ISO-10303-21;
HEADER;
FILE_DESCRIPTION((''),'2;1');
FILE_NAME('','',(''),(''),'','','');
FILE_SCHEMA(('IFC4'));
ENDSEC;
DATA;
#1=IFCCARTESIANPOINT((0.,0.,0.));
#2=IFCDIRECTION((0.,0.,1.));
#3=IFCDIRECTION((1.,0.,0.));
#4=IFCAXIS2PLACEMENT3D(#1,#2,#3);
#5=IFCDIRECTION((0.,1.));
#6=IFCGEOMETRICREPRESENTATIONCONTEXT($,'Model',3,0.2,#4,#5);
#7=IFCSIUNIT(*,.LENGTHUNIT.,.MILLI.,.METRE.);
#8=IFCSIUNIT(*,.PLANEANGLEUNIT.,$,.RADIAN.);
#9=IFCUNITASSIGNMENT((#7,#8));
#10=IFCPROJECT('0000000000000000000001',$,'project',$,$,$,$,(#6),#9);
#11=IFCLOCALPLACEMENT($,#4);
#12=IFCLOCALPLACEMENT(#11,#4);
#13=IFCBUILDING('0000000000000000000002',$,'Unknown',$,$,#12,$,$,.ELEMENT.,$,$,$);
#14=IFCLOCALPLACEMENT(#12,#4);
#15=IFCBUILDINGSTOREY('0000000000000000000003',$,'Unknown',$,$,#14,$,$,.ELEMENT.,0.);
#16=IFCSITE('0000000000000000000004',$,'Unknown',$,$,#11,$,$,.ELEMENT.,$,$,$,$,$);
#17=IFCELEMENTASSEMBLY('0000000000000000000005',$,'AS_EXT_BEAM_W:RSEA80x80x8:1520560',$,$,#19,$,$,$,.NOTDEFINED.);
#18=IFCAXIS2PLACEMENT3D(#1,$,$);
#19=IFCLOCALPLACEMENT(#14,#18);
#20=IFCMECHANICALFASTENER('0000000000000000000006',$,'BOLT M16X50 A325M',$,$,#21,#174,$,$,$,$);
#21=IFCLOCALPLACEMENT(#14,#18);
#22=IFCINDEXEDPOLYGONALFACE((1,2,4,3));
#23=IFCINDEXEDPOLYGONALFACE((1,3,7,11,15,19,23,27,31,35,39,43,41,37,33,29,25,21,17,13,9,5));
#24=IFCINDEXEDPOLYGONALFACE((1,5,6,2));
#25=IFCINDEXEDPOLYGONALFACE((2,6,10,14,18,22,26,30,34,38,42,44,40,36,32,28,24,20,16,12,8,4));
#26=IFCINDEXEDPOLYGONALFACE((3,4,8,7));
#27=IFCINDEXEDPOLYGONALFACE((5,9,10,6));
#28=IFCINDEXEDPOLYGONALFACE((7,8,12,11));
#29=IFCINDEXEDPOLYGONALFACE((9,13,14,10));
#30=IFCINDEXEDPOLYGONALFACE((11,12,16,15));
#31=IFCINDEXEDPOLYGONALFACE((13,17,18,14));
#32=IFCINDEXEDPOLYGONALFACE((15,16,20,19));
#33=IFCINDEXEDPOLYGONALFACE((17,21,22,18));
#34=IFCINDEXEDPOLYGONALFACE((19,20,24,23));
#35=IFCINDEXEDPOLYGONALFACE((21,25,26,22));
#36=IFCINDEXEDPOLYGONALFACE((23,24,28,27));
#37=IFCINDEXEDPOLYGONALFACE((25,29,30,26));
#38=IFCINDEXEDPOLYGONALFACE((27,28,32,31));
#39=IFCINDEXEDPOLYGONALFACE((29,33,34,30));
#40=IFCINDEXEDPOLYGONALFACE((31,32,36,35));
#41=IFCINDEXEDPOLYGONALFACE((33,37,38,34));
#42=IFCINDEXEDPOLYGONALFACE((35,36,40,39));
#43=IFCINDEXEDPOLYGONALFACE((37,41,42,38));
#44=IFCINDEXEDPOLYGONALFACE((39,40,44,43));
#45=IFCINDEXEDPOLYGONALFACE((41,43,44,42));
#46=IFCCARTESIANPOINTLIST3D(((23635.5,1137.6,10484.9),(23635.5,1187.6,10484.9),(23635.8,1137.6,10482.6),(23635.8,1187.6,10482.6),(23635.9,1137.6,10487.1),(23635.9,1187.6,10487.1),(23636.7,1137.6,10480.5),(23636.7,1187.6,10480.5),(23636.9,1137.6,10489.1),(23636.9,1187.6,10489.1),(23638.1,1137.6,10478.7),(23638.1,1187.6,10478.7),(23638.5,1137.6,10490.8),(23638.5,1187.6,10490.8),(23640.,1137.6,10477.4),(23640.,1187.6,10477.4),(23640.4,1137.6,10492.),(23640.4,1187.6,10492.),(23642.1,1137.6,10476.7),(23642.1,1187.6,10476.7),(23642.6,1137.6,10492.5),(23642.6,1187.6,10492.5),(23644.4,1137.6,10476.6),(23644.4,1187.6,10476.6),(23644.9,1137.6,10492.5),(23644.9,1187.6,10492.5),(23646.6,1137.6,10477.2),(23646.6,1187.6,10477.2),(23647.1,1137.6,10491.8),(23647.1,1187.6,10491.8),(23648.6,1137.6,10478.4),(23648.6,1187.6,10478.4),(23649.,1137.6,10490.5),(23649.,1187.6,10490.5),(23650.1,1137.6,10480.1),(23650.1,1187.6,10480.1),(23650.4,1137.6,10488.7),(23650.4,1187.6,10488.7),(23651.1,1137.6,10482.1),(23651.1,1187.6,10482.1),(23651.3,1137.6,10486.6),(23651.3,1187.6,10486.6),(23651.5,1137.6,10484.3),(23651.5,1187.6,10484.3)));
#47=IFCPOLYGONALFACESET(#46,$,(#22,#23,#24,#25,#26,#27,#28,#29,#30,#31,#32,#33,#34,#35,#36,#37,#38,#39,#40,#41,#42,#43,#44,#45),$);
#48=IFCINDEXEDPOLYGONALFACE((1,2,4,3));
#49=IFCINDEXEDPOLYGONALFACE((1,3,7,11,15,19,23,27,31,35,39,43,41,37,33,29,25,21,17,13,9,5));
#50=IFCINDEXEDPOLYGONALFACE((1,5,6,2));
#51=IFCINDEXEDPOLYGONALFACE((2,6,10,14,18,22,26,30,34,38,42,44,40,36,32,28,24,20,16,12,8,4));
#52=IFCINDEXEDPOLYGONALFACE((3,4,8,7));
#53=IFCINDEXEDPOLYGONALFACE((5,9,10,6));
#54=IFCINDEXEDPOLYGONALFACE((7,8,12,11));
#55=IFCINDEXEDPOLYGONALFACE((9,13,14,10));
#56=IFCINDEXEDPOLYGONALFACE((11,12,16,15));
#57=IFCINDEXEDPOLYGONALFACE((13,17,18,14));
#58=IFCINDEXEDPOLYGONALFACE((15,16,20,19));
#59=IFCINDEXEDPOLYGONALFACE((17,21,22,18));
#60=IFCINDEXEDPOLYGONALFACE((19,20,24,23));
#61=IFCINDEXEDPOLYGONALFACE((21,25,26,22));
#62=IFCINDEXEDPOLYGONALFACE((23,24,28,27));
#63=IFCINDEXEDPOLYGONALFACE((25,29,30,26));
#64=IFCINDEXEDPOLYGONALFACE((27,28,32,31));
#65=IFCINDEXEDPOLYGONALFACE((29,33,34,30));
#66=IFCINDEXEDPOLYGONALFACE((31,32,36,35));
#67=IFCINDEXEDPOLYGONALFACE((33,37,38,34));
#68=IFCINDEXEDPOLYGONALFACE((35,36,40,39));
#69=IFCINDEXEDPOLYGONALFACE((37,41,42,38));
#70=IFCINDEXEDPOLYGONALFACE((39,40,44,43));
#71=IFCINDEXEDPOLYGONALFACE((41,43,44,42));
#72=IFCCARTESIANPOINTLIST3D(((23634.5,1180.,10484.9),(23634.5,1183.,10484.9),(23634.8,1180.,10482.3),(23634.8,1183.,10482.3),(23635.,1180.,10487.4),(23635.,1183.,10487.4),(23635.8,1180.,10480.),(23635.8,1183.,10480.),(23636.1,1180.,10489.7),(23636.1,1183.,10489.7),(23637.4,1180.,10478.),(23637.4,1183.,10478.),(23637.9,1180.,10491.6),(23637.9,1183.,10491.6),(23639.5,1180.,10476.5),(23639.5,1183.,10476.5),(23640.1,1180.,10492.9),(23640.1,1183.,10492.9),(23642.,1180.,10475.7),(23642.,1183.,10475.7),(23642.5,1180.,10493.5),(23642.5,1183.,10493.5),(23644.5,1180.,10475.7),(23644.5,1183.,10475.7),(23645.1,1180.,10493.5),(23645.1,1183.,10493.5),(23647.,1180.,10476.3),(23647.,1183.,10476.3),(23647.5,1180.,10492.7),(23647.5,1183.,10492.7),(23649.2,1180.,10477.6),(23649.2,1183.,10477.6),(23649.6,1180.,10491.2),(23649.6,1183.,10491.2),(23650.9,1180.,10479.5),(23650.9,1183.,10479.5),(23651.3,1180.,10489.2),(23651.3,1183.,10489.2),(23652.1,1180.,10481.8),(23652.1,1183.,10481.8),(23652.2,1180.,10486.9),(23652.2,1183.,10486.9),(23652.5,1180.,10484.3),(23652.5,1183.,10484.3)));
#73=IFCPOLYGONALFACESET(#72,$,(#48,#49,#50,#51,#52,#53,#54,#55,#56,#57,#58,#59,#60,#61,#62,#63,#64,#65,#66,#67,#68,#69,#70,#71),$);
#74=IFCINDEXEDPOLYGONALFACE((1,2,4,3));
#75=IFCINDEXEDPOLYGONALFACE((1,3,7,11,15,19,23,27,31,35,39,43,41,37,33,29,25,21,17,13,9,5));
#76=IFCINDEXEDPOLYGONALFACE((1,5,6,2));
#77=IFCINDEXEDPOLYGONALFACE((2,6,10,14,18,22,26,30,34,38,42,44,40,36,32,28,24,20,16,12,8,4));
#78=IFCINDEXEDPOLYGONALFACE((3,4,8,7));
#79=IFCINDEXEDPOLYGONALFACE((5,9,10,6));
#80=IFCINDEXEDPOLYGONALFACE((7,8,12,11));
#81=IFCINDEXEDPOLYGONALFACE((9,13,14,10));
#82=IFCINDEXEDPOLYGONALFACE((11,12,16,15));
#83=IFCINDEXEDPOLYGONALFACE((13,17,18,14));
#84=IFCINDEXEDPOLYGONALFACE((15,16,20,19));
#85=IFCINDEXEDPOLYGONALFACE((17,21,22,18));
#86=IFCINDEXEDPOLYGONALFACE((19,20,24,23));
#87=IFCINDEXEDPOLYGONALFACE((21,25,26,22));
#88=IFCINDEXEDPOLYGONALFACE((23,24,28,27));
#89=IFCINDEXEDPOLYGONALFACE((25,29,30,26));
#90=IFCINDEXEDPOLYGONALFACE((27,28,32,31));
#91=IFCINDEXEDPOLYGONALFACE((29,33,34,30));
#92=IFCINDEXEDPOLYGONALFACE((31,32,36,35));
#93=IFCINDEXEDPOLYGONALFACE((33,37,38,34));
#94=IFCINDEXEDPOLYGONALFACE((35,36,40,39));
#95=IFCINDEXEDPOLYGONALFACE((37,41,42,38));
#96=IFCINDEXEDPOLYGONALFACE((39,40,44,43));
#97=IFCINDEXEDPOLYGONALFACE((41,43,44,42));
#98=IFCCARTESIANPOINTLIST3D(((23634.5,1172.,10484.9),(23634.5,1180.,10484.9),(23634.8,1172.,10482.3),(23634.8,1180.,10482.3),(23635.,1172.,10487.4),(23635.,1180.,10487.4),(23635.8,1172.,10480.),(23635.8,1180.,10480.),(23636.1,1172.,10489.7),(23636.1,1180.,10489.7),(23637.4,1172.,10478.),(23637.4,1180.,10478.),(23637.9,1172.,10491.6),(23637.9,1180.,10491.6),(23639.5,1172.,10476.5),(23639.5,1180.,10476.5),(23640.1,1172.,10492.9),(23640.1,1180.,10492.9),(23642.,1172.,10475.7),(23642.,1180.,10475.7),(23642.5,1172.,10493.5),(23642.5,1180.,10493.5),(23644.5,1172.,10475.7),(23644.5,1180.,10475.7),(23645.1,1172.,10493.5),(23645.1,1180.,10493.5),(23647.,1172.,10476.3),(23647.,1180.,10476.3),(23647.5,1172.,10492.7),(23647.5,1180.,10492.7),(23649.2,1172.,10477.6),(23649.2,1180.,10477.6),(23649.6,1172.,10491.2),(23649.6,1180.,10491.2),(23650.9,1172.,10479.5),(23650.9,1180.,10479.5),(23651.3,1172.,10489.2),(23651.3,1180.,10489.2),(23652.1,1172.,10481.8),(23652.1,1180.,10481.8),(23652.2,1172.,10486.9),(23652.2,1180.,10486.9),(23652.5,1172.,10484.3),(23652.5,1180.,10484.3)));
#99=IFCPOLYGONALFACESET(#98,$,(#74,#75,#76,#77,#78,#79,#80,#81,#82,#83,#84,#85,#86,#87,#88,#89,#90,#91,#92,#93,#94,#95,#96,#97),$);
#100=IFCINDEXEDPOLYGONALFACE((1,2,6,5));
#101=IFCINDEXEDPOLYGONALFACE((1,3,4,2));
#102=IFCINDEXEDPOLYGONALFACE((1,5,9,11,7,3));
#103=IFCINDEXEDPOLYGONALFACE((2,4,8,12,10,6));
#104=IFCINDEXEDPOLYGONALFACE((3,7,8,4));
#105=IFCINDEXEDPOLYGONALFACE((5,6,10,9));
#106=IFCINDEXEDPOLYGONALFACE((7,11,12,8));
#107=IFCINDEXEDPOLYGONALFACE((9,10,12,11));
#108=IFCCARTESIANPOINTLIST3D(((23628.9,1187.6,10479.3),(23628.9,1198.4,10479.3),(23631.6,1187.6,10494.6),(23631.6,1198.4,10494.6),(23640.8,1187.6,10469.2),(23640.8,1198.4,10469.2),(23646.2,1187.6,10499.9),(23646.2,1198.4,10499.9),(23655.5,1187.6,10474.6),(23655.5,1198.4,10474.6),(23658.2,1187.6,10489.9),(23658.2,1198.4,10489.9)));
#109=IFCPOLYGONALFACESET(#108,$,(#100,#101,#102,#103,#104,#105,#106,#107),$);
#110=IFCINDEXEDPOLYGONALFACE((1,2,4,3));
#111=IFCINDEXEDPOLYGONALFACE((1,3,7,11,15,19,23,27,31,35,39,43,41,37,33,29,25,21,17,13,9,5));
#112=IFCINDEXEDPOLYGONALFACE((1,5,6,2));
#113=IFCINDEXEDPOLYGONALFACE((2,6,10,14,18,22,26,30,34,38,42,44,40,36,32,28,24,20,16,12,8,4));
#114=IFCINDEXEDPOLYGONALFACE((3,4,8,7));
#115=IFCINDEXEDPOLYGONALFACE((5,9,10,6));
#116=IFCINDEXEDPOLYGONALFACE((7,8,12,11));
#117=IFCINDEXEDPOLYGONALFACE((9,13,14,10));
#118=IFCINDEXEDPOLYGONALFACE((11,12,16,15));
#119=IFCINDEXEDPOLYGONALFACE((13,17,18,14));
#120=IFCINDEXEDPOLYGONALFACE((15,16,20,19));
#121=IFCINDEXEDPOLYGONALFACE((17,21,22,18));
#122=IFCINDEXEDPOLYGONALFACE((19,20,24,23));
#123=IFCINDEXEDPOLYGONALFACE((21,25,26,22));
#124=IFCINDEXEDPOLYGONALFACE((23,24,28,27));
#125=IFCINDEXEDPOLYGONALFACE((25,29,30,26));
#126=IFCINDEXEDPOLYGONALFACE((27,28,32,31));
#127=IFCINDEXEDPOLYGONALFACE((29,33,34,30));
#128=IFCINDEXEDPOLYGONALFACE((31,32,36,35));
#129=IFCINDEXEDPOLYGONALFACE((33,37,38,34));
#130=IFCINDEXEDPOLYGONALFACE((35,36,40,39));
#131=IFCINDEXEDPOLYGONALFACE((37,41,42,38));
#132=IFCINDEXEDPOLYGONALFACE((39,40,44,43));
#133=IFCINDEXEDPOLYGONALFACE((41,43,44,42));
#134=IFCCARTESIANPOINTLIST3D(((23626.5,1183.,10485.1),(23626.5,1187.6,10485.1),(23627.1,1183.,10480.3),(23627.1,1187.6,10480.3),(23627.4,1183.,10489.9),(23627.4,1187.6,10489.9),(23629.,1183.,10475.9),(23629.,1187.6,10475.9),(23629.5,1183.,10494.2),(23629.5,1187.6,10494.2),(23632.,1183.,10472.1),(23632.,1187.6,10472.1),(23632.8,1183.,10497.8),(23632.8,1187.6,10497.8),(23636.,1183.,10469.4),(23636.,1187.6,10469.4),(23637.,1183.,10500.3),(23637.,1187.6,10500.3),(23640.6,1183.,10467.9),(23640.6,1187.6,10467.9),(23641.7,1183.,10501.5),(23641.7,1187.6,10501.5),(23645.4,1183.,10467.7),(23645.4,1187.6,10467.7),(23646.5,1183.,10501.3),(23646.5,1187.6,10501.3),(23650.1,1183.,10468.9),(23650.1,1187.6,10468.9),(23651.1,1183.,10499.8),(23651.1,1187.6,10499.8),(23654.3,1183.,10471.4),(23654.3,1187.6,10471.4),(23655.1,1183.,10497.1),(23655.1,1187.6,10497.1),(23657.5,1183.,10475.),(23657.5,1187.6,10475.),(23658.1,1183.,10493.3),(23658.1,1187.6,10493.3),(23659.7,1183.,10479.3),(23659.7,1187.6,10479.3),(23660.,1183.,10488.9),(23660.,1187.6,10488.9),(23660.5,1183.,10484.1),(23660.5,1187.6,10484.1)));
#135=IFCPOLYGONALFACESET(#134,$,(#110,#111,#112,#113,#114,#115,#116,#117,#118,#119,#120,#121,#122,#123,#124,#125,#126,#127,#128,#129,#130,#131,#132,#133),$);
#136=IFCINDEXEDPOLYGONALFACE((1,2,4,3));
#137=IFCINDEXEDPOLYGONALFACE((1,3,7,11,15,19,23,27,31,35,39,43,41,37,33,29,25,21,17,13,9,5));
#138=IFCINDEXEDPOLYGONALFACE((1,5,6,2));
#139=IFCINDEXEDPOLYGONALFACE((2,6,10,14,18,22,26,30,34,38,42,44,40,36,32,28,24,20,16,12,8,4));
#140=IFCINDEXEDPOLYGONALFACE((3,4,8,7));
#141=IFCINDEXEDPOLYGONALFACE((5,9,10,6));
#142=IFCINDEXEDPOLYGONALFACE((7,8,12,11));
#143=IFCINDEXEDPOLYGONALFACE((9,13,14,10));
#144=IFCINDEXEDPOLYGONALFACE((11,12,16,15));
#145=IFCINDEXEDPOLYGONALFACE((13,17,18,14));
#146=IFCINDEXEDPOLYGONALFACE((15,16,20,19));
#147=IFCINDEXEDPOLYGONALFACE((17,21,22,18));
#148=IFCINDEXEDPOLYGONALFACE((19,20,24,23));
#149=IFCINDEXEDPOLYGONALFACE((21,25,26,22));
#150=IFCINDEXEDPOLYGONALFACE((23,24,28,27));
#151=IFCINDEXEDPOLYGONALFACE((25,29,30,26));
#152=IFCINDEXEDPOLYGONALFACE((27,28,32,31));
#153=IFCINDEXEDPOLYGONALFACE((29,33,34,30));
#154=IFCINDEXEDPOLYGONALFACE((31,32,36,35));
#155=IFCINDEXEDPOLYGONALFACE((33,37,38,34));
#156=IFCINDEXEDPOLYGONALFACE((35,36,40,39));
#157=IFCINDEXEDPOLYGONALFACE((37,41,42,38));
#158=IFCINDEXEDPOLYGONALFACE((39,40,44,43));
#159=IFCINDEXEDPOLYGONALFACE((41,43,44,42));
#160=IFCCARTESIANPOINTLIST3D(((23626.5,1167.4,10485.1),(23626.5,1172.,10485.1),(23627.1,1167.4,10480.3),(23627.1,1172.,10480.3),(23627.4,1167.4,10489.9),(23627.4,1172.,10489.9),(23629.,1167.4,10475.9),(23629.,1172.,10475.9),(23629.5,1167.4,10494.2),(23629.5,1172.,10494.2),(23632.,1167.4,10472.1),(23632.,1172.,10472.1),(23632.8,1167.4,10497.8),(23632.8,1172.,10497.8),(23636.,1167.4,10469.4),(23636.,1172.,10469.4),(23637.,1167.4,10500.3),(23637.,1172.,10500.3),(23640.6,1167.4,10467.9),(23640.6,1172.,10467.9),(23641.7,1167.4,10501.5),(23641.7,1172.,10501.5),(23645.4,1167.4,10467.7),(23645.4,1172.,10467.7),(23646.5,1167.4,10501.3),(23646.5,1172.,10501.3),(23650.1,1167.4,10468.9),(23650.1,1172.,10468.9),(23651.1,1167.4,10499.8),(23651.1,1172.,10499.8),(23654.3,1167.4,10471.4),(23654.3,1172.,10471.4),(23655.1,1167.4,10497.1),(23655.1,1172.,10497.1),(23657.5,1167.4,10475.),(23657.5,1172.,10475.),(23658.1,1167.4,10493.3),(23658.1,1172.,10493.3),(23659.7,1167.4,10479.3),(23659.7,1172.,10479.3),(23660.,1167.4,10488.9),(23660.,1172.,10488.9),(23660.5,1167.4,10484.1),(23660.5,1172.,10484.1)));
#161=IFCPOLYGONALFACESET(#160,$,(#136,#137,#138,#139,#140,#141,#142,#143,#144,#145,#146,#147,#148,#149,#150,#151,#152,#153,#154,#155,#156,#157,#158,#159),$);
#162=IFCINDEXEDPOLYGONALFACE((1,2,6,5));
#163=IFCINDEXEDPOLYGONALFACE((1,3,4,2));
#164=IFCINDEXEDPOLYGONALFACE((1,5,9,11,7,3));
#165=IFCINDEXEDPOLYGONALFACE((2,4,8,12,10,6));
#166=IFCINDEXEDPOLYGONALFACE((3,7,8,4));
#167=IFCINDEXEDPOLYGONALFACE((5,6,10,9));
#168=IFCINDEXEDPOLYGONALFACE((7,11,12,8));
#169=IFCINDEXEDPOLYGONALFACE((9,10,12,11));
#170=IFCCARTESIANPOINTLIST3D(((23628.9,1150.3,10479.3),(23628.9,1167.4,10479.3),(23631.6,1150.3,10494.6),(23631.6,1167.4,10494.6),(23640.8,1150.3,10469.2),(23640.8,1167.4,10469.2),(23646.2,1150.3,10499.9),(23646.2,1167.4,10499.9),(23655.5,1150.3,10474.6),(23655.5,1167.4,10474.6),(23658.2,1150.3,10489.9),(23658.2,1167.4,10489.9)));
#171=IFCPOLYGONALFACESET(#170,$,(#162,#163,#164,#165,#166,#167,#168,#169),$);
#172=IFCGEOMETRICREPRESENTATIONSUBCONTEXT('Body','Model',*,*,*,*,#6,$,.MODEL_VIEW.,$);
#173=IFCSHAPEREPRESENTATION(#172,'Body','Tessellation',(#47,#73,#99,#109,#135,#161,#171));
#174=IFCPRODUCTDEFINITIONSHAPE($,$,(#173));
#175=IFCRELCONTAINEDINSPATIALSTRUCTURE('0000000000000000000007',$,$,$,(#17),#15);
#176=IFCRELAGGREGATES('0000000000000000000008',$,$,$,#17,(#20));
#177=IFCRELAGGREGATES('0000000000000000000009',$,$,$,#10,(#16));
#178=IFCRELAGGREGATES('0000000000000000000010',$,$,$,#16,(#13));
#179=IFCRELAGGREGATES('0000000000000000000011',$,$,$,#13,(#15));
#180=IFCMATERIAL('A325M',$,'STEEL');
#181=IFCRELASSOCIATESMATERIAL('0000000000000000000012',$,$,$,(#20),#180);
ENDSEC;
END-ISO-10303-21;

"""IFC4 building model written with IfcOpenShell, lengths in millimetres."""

from ifc_helpers import new_model, si_unit, direction, frame, origin_with_axes, place, context, subcontext, project, spatial, line, arc, indexed_curve, outline, extrude, source, transform, mapped, material, element, aggregate, save


model = new_model("IFC4")

# Units and contexts
model_context = context("Model", 3, precision=0.2, world=origin_with_axes(), true_north=direction((0.0, 1.0)))
body_context = subcontext(model_context, "Body", "Model", "MODEL_VIEW")
ifc_project = project(units=[si_unit("LENGTHUNIT", "METRE", prefix="MILLI"), si_unit("PLANEANGLEUNIT", "RADIAN")], contexts=[model_context])

# Site, building, storey
site_placement = place(None, origin_with_axes())
site = spatial("IfcSite", under=ifc_project, at=site_placement, Name="Unknown", CompositionType="ELEMENT")
building_placement = place(site_placement, origin_with_axes())
building = spatial("IfcBuilding", under=site, at=building_placement, Name="Unknown", CompositionType="ELEMENT")
storey_placement = place(building_placement, origin_with_axes())
storey = spatial("IfcBuildingStorey", under=building, at=storey_placement, Name="Unknown", CompositionType="ELEMENT", Elevation=0.0)

# Element assembly
assembly_1_placement = place(storey_placement, frame((23581.1, 1140.0, 10490.5), z_axis=(0.0, -1.0, 0.0), x_axis=(0.984808, 0.0, -0.173648)))
assembly_1 = element("IfcElementAssembly", 1, at=assembly_1_placement, inside=storey, Name="AS_EXT_BEAM_W:RSEA80x80x8:1520560", PredefinedType="NOTDEFINED")

# Mechanical fastener
ifc_material_1 = material(Name="A325M", Category="STEEL")
shared_shape = source(origin_with_axes(), body_context, "Body", "SweptSolid", [
    extrude(outline(indexed_curve([(8.0, 0.0), (0.0, 8.0), (-8.0, 0.0), (0.0, -8.0)], segments=[arc(1, 2, 3), arc(3, 4, 1)])), frame((0.0, 0.0, 15.6), z_axis=(0.0, 0.0, -1.0), x_axis=(0.0, 1.0, 0.0)), (0.0, 0.0, 1.0), 50.0),
    extrude(outline(indexed_curve([(9.0, 0.0), (0.0, 9.0), (-9.0, 0.0), (0.0, -9.0)], segments=[arc(1, 2, 3), arc(3, 4, 1)])), frame((0.0, 0.0, 11.0), z_axis=(0.0, 0.0, -1.0), x_axis=(0.0, 1.0, 0.0)), (0.0, 0.0, 1.0), 3.0),
    extrude(outline(indexed_curve([(9.0, 0.0), (0.0, 9.0), (-9.0, 0.0), (0.0, -9.0)], segments=[arc(1, 2, 3), arc(3, 4, 1)])), frame((0.0, 0.0, 8.0), z_axis=(0.0, 0.0, -1.0), x_axis=(0.0, 1.0, 0.0)), (0.0, 0.0, 1.0), 8.0),
    extrude(outline(indexed_curve([(15.6, 0.0), (7.8, 13.5), (-7.8, 13.5), (-15.6, 0.0), (-7.8, -13.5), (7.8, -13.5)], segments=[line(1, 2, 3, 4, 5, 6, 1)])), frame((0.0, 0.0, 26.4), z_axis=(0.0, 0.0, -1.0), x_axis=(0.0, 1.0, 0.0)), (0.0, 0.0, 1.0), 10.8),
    extrude(outline(indexed_curve([(17.0, 0.0), (0.0, 17.0), (-17.0, 0.0), (0.0, -17.0)], segments=[arc(1, 2, 3), arc(3, 4, 1)])), frame((0.0, 0.0, 15.6), z_axis=(0.0, 0.0, -1.0), x_axis=(0.0, 1.0, 0.0)), (0.0, 0.0, 1.0), 4.6),
    extrude(outline(indexed_curve([(17.0, 0.0), (0.0, 17.0), (-17.0, 0.0), (0.0, -17.0)], segments=[arc(1, 2, 3), arc(3, 4, 1)])), frame((0.0, 0.0, 0.0), z_axis=(0.0, 0.0, -1.0), x_axis=(0.0, 1.0, 0.0)), (0.0, 0.0, 1.0), 4.6),
    extrude(outline(indexed_curve([(15.6, 0.0), (7.8, 13.5), (-7.8, 13.5), (-15.6, 0.0), (-7.8, -13.5), (7.8, -13.5)], segments=[line(1, 2, 3, 4, 5, 6, 1)])), frame((0.0, 0.0, -4.6), z_axis=(0.0, 0.0, -1.0), x_axis=(0.0, 1.0, 0.0)), (0.0, 0.0, 1.0), 17.1),
])
mechanical_fastener_1_placement = place(assembly_1_placement, frame((62.5, 5.0, -32.0), z_axis=(0.0, 0.0, -1.0), x_axis=(1.0, 0.0, 0.0)))
mechanical_fastener_1 = element("IfcMechanicalFastener", 2, at=mechanical_fastener_1_placement, material=ifc_material_1, Name="BOLT M16X50 A325M", context=body_context, shape_type="MappedRepresentation", body=[
    mapped(shared_shape, transform((0.0, 0.0, 0.0))),
])
aggregate(assembly_1, [mechanical_fastener_1])

save(model, "model.ifc")
